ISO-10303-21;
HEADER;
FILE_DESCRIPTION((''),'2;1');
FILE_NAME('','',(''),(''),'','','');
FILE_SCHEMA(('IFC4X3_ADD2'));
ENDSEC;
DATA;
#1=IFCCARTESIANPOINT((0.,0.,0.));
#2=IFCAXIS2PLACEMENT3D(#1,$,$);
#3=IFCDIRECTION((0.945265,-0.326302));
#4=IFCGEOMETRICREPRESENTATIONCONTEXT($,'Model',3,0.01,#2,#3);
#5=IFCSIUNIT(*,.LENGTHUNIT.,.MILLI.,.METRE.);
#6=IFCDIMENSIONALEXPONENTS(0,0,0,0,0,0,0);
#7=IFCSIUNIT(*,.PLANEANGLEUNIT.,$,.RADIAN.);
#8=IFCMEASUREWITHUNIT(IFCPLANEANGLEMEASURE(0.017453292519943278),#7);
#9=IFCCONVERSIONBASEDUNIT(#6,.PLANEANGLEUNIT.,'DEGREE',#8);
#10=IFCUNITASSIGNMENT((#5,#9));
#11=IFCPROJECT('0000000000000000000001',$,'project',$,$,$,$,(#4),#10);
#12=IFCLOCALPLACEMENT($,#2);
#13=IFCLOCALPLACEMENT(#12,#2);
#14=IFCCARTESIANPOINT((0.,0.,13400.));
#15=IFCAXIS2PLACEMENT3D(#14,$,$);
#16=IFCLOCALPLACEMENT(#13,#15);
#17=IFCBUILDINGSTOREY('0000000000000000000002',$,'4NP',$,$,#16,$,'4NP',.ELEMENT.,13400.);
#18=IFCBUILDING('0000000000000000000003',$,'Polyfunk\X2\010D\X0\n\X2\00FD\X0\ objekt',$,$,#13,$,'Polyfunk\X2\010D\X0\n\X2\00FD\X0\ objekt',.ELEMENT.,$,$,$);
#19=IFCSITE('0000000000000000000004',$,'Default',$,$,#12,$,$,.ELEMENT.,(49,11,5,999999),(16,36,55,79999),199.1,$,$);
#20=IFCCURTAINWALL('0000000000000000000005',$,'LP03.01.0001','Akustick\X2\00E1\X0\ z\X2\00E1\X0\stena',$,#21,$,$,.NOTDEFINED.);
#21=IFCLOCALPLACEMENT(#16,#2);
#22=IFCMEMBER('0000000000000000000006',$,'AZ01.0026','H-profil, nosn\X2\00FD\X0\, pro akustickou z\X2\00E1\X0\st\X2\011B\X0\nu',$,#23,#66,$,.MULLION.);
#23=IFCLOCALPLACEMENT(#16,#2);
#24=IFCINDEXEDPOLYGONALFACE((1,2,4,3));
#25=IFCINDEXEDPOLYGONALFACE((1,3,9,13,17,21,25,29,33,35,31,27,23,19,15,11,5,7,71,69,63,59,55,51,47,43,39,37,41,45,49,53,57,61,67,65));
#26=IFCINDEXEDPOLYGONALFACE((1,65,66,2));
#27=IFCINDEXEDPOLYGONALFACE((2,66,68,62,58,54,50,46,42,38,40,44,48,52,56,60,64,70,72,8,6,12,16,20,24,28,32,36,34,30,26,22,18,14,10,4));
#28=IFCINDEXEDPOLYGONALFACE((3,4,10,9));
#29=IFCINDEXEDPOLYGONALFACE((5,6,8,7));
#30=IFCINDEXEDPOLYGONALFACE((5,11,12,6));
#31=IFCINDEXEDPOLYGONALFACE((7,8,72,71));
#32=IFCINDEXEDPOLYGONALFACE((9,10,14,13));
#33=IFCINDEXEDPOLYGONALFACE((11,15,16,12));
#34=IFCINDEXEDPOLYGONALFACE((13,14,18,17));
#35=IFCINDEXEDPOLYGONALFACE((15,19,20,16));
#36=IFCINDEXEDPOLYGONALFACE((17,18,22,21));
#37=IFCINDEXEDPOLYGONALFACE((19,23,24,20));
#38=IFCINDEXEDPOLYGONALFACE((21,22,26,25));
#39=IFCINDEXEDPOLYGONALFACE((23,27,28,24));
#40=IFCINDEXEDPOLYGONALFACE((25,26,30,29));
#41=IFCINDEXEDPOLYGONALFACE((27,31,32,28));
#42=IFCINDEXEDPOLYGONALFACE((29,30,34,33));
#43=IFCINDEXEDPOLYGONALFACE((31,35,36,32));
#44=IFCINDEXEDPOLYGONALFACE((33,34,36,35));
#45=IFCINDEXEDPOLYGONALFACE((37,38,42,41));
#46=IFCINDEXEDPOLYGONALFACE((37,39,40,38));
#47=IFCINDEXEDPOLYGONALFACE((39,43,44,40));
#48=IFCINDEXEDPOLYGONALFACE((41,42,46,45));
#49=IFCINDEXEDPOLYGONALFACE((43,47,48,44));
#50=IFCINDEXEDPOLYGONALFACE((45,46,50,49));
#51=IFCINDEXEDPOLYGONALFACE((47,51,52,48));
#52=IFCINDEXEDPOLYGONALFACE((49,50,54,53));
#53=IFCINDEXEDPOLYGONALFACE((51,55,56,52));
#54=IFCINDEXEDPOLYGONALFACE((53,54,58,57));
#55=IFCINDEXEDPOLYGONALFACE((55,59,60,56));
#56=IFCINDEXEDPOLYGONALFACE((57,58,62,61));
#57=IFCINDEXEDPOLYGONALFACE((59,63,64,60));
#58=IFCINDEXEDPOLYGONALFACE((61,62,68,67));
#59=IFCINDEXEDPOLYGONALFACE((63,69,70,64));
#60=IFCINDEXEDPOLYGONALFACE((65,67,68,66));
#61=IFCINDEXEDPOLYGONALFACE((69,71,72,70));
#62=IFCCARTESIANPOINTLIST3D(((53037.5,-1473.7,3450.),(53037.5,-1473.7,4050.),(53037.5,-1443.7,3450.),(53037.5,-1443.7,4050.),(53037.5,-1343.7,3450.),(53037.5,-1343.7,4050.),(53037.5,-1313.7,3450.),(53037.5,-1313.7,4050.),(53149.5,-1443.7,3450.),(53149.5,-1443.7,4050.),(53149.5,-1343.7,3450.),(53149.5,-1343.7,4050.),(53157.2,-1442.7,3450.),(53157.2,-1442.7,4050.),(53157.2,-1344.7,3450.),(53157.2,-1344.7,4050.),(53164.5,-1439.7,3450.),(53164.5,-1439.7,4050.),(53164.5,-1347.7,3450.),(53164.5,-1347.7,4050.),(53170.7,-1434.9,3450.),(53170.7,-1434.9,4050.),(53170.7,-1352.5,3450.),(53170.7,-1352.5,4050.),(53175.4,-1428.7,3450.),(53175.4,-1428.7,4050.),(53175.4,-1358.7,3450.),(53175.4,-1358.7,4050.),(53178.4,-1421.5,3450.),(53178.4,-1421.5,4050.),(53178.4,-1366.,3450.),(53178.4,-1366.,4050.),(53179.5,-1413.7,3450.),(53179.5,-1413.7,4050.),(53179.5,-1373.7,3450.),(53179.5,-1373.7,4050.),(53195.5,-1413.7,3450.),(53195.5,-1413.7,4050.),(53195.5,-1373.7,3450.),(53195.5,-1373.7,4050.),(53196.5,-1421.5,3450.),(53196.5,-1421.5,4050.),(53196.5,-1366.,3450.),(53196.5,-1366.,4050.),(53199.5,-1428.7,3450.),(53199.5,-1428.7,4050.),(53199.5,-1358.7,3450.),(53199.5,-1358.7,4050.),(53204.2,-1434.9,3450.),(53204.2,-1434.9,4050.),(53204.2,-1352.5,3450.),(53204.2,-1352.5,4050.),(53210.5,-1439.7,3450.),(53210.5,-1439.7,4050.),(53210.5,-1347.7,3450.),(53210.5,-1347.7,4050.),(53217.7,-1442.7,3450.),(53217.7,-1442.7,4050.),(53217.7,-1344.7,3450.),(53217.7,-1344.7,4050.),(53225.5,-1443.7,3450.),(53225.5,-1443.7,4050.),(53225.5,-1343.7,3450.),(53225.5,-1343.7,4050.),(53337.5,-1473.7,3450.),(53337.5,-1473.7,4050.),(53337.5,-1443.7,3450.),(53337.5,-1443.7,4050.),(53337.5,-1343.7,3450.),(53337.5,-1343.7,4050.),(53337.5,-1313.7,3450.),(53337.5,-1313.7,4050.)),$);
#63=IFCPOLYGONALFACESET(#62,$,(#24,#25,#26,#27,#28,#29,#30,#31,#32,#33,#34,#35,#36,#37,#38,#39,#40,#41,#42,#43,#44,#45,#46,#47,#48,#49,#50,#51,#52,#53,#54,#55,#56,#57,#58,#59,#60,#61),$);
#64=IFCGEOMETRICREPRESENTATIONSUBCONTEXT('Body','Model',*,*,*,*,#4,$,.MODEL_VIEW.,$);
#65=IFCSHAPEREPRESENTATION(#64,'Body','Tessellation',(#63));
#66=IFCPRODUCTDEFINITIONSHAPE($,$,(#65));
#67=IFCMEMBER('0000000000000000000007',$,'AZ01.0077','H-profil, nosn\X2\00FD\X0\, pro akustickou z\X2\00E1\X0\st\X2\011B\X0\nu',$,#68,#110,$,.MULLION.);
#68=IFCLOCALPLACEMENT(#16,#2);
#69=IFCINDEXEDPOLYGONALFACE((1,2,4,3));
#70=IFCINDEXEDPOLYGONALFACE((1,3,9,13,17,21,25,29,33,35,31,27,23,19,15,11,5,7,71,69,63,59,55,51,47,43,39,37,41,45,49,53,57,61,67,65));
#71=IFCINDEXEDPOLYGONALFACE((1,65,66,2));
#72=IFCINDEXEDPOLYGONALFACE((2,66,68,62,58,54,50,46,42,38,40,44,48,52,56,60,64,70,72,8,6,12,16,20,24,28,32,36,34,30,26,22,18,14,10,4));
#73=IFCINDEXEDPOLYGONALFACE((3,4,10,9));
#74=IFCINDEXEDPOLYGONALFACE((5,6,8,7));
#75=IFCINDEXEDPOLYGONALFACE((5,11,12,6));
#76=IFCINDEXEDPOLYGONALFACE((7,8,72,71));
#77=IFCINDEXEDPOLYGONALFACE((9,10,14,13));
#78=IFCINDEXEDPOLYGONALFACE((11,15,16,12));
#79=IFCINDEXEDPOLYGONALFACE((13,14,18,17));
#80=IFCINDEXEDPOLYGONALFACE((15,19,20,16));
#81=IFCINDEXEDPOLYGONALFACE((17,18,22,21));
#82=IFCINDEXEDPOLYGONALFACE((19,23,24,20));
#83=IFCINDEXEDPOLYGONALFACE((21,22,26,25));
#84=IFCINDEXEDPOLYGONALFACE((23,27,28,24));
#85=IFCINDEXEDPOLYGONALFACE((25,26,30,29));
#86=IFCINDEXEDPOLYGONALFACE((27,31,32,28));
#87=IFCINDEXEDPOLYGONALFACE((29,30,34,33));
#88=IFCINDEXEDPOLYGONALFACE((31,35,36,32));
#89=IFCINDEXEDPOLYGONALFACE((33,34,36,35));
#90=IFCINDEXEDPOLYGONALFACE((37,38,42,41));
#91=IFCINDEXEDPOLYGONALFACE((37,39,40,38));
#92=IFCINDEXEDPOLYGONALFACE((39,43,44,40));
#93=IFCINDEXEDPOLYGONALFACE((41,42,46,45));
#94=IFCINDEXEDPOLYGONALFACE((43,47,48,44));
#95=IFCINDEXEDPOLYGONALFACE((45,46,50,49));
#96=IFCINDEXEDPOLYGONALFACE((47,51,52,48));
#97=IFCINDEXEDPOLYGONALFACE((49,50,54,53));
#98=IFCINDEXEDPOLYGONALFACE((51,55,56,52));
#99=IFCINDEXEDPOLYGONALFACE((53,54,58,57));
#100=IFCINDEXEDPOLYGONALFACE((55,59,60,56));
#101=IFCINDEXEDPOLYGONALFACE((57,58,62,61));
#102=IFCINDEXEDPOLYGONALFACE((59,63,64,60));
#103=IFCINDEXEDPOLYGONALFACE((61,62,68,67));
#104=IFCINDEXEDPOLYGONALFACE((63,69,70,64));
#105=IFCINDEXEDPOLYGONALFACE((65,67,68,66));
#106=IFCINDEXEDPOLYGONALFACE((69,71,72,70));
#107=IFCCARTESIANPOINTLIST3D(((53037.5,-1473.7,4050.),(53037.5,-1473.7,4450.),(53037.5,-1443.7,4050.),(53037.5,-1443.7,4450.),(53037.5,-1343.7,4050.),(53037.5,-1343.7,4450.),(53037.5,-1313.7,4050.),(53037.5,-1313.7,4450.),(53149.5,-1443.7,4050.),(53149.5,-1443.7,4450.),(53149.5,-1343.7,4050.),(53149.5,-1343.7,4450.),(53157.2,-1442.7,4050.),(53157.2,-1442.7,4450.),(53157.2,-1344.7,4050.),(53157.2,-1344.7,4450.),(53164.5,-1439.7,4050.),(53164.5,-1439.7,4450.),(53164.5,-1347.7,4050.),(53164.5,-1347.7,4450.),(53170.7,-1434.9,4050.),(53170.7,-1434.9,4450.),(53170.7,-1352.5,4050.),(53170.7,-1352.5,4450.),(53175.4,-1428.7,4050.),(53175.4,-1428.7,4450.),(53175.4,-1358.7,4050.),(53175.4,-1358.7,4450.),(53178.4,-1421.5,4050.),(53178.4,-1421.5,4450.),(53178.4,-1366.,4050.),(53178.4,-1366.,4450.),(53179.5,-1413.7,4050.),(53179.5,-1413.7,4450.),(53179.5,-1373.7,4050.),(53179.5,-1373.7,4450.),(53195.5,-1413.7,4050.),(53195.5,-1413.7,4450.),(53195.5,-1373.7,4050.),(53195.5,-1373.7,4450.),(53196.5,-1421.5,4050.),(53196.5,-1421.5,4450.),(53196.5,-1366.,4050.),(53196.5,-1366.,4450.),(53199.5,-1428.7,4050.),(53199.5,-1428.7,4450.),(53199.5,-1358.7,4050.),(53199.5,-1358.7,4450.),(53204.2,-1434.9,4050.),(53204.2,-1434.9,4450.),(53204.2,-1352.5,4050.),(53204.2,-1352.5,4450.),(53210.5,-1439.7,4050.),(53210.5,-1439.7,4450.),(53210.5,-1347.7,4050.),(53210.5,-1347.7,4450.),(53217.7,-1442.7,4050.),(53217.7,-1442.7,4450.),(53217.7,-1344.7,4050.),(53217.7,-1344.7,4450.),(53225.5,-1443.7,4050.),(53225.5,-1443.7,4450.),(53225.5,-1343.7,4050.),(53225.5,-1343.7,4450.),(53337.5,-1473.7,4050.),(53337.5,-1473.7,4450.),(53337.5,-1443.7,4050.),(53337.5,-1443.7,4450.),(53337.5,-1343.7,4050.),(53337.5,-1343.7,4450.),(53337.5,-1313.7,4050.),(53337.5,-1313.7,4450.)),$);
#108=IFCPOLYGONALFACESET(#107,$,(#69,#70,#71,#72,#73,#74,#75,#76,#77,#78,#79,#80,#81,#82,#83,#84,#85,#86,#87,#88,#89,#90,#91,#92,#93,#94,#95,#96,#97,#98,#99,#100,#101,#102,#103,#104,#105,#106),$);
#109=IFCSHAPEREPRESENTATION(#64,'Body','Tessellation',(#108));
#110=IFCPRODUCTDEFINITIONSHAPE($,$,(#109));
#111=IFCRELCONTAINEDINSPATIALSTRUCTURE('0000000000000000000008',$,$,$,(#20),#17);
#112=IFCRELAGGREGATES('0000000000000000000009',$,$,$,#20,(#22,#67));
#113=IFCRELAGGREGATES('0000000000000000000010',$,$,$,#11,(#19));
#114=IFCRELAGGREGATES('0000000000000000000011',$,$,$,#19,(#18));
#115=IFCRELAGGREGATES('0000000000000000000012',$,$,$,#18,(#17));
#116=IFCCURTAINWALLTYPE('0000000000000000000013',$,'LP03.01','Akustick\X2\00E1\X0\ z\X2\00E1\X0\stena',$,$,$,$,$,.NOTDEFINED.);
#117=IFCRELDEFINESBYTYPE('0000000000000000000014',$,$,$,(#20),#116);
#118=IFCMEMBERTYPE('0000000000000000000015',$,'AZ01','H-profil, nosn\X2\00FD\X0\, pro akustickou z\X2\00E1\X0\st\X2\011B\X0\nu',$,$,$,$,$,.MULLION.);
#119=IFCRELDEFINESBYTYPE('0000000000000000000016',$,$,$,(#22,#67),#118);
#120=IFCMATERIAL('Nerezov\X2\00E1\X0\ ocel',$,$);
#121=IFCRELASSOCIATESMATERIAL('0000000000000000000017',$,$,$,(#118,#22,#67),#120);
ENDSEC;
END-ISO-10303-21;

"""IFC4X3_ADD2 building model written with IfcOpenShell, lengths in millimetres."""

from ifc_helpers import new_model, entity, si_unit, converted_unit, direction, frame, frame_2d, origin, place, context, subcontext, project, spatial, polyline, circle_curve, parameter, trimmed, segment, composite_curve, outline, extrude, source, transform, mapped, material, material_profile, profile_set, profile_usage, type_object, element, aggregate, save


model = new_model("IFC4X3_ADD2")

# Units and contexts
model_context = context("Model", 3, precision=0.01, world=origin(), true_north=direction((0.945265, -0.326302)))
body_context = subcontext(model_context, "Body", "Model", "MODEL_VIEW")
ifc_project = project(units=[si_unit("LENGTHUNIT", "METRE", prefix="MILLI"), converted_unit("PLANEANGLEUNIT", "DEGREE", entity("IfcPlaneAngleMeasure", 0.017453292519943278), si_unit("PLANEANGLEUNIT", "RADIAN"), dimensions=[0, 0, 0, 0, 0, 0, 0])], contexts=[model_context])

# Site, building, storey
site_placement = place(None, origin())
site = spatial("IfcSite", under=ifc_project, at=site_placement, Name="Default", CompositionType="ELEMENT", RefLatitude=(49, 11, 5, 999999), RefLongitude=(16, 36, 55, 79999), RefElevation=199.1)
building_placement = place(site_placement, origin())
building = spatial("IfcBuilding", under=site, at=building_placement, Name="Polyfunkčný objekt", LongName="Polyfunkčný objekt", CompositionType="ELEMENT")
storey_placement = place(building_placement, frame((0.0, 0.0, 13400.0)))
storey = spatial("IfcBuildingStorey", under=building, at=storey_placement, Name="4NP", LongName="4NP", CompositionType="ELEMENT", Elevation=13400.0)

# Curtain wall, members
curtain_wall_type_1 = type_object("IfcCurtainWallType", Name="LP03.01", Description="Akustická zástena", PredefinedType="NOTDEFINED")
curtain_wall_1_placement = place(storey_placement, frame((0.0, 0.0, -13400.0)))
curtain_wall_1 = element("IfcCurtainWall", 1, at=curtain_wall_1_placement, inside=storey, type_object=curtain_wall_type_1, Name="LP03.01.0001", Description="Akustická zástena", PredefinedType="NOTDEFINED")
ifc_material_1 = material(Name="Nerezová ocel")
ifc_material_profile = material_profile(ifc_material_1, outline(composite_curve([segment(polyline([(50.0, -150.0), (80.0, -150.0)]), True, "CONTINUOUS"), segment(polyline([(80.0, -150.0), (80.0, 150.0)]), True, "CONTINUOUS"), segment(polyline([(80.0, 150.0), (50.0, 150.0)]), True, "CONTINUOUS"), segment(polyline([(50.0, 150.0), (50.0, 38.0)]), True, "CONTINUOUS"), segment(trimmed(circle_curve(frame_2d((20.0, 38.0), x_axis=(0.0, 1.0)), 30.0), [parameter(180.0)], [parameter(270.0)], True, "PARAMETER"), False, "CONTINUOUS"), segment(polyline([(20.0, 8.0), (-20.0, 8.0)]), True, "CONTINUOUS"), segment(trimmed(circle_curve(frame_2d((-20.0, 38.0), x_axis=(0.0, 1.0)), 30.0), [parameter(90.0)], [parameter(180.0)], True, "PARAMETER"), False, "CONTINUOUS"), segment(polyline([(-50.0, 38.0), (-50.0, 150.0)]), True, "CONTINUOUS"), segment(polyline([(-50.0, 150.0), (-80.0, 150.0)]), True, "CONTINUOUS"), segment(polyline([(-80.0, 150.0), (-80.0, -150.0)]), True, "CONTINUOUS"), segment(polyline([(-80.0, -150.0), (-50.0, -150.0)]), True, "CONTINUOUS"), segment(polyline([(-50.0, -150.0), (-50.0, -38.0)]), True, "CONTINUOUS"), segment(trimmed(circle_curve(frame_2d((-20.0, -38.0), x_axis=(0.0, 1.0)), 30.0), [parameter(0.0)], [parameter(90.0)], True, "PARAMETER"), False, "CONTINUOUS"), segment(polyline([(-20.0, -8.0), (20.0, -8.0)]), True, "CONTINUOUS"), segment(trimmed(circle_curve(frame_2d((20.0, -38.0), x_axis=(0.0, 1.0)), 30.0), [parameter(270.0)], [parameter(0.0)], True, "PARAMETER"), False, "CONTINUOUS"), segment(polyline([(50.0, -38.0), (50.0, -150.0)]), True, "CONTINUOUS")], self_intersect=False)), Name="Profil zástena")
ifc_profile_set = profile_set([ifc_material_profile], Name="Profil zástena")
ifc_profile_usage = profile_usage(ifc_profile_set)
member_type = type_object("IfcMemberType", Name="AZ01", Description="H-profil, nosný, pro akustickou zástěnu", PredefinedType="MULLION", material=ifc_profile_set)
shared_shape_1 = source(origin(), body_context, "Body", "SweptSolid", [
    extrude(outline(composite_curve([segment(polyline([(50.0, -150.0), (80.0, -150.0)]), True, "CONTINUOUS"), segment(polyline([(80.0, -150.0), (80.0, 150.0)]), True, "CONTINUOUS"), segment(polyline([(80.0, 150.0), (50.0, 150.0)]), True, "CONTINUOUS"), segment(polyline([(50.0, 150.0), (50.0, 38.0)]), True, "CONTINUOUS"), segment(trimmed(circle_curve(frame_2d((20.0, 38.0), x_axis=(0.0, 1.0)), 30.0), [parameter(180.0)], [parameter(270.0)], True, "PARAMETER"), False, "CONTINUOUS"), segment(polyline([(20.0, 8.0), (-20.0, 8.0)]), True, "CONTINUOUS"), segment(trimmed(circle_curve(frame_2d((-20.0, 38.0), x_axis=(0.0, 1.0)), 30.0), [parameter(90.0)], [parameter(180.0)], True, "PARAMETER"), False, "CONTINUOUS"), segment(polyline([(-50.0, 38.0), (-50.0, 150.0)]), True, "CONTINUOUS"), segment(polyline([(-50.0, 150.0), (-80.0, 150.0)]), True, "CONTINUOUS"), segment(polyline([(-80.0, 150.0), (-80.0, -150.0)]), True, "CONTINUOUS"), segment(polyline([(-80.0, -150.0), (-50.0, -150.0)]), True, "CONTINUOUS"), segment(polyline([(-50.0, -150.0), (-50.0, -38.0)]), True, "CONTINUOUS"), segment(trimmed(circle_curve(frame_2d((-20.0, -38.0), x_axis=(0.0, 1.0)), 30.0), [parameter(0.0)], [parameter(90.0)], True, "PARAMETER"), False, "CONTINUOUS"), segment(polyline([(-20.0, -8.0), (20.0, -8.0)]), True, "CONTINUOUS"), segment(trimmed(circle_curve(frame_2d((20.0, -38.0), x_axis=(0.0, 1.0)), 30.0), [parameter(270.0)], [parameter(0.0)], True, "PARAMETER"), False, "CONTINUOUS"), segment(polyline([(50.0, -38.0), (50.0, -150.0)]), True, "CONTINUOUS")], self_intersect=False)), frame((0.0, 0.0, -600.0), z_axis=(0.0, 0.0, 1.0), x_axis=(0.0, -1.0, 0.0)), (0.0, 0.0, 1.0), 600.0),
])
member_1_placement = place(curtain_wall_1_placement, frame((53187.5, -1393.7, 16850.0), z_axis=(0.0, 0.0, -1.0), x_axis=(1.0, 0.0, 0.0)))
member_1 = element("IfcMember", 2, at=member_1_placement, type_object=member_type, material=ifc_profile_usage, Name="AZ01.0026", Description="H-profil, nosný, pro akustickou zástěnu", PredefinedType="MULLION", context=body_context, shape_type="MappedRepresentation", body=[
    mapped(shared_shape_1, transform((0.0, 0.0, 0.0), scale=1.0)),
])
shared_shape_2 = source(origin(), body_context, "Body", "SweptSolid", [
    extrude(outline(composite_curve([segment(polyline([(50.0, -150.0), (80.0, -150.0)]), True, "CONTINUOUS"), segment(polyline([(80.0, -150.0), (80.0, 150.0)]), True, "CONTINUOUS"), segment(polyline([(80.0, 150.0), (50.0, 150.0)]), True, "CONTINUOUS"), segment(polyline([(50.0, 150.0), (50.0, 38.0)]), True, "CONTINUOUS"), segment(trimmed(circle_curve(frame_2d((20.0, 38.0), x_axis=(0.0, 1.0)), 30.0), [parameter(180.0)], [parameter(270.0)], True, "PARAMETER"), False, "CONTINUOUS"), segment(polyline([(20.0, 8.0), (-20.0, 8.0)]), True, "CONTINUOUS"), segment(trimmed(circle_curve(frame_2d((-20.0, 38.0), x_axis=(0.0, 1.0)), 30.0), [parameter(90.0)], [parameter(180.0)], True, "PARAMETER"), False, "CONTINUOUS"), segment(polyline([(-50.0, 38.0), (-50.0, 150.0)]), True, "CONTINUOUS"), segment(polyline([(-50.0, 150.0), (-80.0, 150.0)]), True, "CONTINUOUS"), segment(polyline([(-80.0, 150.0), (-80.0, -150.0)]), True, "CONTINUOUS"), segment(polyline([(-80.0, -150.0), (-50.0, -150.0)]), True, "CONTINUOUS"), segment(polyline([(-50.0, -150.0), (-50.0, -38.0)]), True, "CONTINUOUS"), segment(trimmed(circle_curve(frame_2d((-20.0, -38.0), x_axis=(0.0, 1.0)), 30.0), [parameter(0.0)], [parameter(90.0)], True, "PARAMETER"), False, "CONTINUOUS"), segment(polyline([(-20.0, -8.0), (20.0, -8.0)]), True, "CONTINUOUS"), segment(trimmed(circle_curve(frame_2d((20.0, -38.0), x_axis=(0.0, 1.0)), 30.0), [parameter(270.0)], [parameter(0.0)], True, "PARAMETER"), False, "CONTINUOUS"), segment(polyline([(50.0, -38.0), (50.0, -150.0)]), True, "CONTINUOUS")], self_intersect=False)), frame((0.0, 0.0, -400.0), z_axis=(0.0, 0.0, 1.0), x_axis=(0.0, -1.0, 0.0)), (0.0, 0.0, 1.0), 400.0),
])
member_2_placement = place(curtain_wall_1_placement, frame((53187.5, -1393.7, 17450.0), z_axis=(0.0, 0.0, -1.0), x_axis=(1.0, 0.0, 0.0)))
member_2 = element("IfcMember", 3, at=member_2_placement, type_object=member_type, material=ifc_profile_usage, Name="AZ01.0077", Description="H-profil, nosný, pro akustickou zástěnu", PredefinedType="MULLION", context=body_context, shape_type="MappedRepresentation", body=[
    mapped(shared_shape_2, transform((0.0, 0.0, 0.0), scale=1.0)),
])

aggregate(curtain_wall_1, [member_1, member_2])

save(model, "model.ifc")
